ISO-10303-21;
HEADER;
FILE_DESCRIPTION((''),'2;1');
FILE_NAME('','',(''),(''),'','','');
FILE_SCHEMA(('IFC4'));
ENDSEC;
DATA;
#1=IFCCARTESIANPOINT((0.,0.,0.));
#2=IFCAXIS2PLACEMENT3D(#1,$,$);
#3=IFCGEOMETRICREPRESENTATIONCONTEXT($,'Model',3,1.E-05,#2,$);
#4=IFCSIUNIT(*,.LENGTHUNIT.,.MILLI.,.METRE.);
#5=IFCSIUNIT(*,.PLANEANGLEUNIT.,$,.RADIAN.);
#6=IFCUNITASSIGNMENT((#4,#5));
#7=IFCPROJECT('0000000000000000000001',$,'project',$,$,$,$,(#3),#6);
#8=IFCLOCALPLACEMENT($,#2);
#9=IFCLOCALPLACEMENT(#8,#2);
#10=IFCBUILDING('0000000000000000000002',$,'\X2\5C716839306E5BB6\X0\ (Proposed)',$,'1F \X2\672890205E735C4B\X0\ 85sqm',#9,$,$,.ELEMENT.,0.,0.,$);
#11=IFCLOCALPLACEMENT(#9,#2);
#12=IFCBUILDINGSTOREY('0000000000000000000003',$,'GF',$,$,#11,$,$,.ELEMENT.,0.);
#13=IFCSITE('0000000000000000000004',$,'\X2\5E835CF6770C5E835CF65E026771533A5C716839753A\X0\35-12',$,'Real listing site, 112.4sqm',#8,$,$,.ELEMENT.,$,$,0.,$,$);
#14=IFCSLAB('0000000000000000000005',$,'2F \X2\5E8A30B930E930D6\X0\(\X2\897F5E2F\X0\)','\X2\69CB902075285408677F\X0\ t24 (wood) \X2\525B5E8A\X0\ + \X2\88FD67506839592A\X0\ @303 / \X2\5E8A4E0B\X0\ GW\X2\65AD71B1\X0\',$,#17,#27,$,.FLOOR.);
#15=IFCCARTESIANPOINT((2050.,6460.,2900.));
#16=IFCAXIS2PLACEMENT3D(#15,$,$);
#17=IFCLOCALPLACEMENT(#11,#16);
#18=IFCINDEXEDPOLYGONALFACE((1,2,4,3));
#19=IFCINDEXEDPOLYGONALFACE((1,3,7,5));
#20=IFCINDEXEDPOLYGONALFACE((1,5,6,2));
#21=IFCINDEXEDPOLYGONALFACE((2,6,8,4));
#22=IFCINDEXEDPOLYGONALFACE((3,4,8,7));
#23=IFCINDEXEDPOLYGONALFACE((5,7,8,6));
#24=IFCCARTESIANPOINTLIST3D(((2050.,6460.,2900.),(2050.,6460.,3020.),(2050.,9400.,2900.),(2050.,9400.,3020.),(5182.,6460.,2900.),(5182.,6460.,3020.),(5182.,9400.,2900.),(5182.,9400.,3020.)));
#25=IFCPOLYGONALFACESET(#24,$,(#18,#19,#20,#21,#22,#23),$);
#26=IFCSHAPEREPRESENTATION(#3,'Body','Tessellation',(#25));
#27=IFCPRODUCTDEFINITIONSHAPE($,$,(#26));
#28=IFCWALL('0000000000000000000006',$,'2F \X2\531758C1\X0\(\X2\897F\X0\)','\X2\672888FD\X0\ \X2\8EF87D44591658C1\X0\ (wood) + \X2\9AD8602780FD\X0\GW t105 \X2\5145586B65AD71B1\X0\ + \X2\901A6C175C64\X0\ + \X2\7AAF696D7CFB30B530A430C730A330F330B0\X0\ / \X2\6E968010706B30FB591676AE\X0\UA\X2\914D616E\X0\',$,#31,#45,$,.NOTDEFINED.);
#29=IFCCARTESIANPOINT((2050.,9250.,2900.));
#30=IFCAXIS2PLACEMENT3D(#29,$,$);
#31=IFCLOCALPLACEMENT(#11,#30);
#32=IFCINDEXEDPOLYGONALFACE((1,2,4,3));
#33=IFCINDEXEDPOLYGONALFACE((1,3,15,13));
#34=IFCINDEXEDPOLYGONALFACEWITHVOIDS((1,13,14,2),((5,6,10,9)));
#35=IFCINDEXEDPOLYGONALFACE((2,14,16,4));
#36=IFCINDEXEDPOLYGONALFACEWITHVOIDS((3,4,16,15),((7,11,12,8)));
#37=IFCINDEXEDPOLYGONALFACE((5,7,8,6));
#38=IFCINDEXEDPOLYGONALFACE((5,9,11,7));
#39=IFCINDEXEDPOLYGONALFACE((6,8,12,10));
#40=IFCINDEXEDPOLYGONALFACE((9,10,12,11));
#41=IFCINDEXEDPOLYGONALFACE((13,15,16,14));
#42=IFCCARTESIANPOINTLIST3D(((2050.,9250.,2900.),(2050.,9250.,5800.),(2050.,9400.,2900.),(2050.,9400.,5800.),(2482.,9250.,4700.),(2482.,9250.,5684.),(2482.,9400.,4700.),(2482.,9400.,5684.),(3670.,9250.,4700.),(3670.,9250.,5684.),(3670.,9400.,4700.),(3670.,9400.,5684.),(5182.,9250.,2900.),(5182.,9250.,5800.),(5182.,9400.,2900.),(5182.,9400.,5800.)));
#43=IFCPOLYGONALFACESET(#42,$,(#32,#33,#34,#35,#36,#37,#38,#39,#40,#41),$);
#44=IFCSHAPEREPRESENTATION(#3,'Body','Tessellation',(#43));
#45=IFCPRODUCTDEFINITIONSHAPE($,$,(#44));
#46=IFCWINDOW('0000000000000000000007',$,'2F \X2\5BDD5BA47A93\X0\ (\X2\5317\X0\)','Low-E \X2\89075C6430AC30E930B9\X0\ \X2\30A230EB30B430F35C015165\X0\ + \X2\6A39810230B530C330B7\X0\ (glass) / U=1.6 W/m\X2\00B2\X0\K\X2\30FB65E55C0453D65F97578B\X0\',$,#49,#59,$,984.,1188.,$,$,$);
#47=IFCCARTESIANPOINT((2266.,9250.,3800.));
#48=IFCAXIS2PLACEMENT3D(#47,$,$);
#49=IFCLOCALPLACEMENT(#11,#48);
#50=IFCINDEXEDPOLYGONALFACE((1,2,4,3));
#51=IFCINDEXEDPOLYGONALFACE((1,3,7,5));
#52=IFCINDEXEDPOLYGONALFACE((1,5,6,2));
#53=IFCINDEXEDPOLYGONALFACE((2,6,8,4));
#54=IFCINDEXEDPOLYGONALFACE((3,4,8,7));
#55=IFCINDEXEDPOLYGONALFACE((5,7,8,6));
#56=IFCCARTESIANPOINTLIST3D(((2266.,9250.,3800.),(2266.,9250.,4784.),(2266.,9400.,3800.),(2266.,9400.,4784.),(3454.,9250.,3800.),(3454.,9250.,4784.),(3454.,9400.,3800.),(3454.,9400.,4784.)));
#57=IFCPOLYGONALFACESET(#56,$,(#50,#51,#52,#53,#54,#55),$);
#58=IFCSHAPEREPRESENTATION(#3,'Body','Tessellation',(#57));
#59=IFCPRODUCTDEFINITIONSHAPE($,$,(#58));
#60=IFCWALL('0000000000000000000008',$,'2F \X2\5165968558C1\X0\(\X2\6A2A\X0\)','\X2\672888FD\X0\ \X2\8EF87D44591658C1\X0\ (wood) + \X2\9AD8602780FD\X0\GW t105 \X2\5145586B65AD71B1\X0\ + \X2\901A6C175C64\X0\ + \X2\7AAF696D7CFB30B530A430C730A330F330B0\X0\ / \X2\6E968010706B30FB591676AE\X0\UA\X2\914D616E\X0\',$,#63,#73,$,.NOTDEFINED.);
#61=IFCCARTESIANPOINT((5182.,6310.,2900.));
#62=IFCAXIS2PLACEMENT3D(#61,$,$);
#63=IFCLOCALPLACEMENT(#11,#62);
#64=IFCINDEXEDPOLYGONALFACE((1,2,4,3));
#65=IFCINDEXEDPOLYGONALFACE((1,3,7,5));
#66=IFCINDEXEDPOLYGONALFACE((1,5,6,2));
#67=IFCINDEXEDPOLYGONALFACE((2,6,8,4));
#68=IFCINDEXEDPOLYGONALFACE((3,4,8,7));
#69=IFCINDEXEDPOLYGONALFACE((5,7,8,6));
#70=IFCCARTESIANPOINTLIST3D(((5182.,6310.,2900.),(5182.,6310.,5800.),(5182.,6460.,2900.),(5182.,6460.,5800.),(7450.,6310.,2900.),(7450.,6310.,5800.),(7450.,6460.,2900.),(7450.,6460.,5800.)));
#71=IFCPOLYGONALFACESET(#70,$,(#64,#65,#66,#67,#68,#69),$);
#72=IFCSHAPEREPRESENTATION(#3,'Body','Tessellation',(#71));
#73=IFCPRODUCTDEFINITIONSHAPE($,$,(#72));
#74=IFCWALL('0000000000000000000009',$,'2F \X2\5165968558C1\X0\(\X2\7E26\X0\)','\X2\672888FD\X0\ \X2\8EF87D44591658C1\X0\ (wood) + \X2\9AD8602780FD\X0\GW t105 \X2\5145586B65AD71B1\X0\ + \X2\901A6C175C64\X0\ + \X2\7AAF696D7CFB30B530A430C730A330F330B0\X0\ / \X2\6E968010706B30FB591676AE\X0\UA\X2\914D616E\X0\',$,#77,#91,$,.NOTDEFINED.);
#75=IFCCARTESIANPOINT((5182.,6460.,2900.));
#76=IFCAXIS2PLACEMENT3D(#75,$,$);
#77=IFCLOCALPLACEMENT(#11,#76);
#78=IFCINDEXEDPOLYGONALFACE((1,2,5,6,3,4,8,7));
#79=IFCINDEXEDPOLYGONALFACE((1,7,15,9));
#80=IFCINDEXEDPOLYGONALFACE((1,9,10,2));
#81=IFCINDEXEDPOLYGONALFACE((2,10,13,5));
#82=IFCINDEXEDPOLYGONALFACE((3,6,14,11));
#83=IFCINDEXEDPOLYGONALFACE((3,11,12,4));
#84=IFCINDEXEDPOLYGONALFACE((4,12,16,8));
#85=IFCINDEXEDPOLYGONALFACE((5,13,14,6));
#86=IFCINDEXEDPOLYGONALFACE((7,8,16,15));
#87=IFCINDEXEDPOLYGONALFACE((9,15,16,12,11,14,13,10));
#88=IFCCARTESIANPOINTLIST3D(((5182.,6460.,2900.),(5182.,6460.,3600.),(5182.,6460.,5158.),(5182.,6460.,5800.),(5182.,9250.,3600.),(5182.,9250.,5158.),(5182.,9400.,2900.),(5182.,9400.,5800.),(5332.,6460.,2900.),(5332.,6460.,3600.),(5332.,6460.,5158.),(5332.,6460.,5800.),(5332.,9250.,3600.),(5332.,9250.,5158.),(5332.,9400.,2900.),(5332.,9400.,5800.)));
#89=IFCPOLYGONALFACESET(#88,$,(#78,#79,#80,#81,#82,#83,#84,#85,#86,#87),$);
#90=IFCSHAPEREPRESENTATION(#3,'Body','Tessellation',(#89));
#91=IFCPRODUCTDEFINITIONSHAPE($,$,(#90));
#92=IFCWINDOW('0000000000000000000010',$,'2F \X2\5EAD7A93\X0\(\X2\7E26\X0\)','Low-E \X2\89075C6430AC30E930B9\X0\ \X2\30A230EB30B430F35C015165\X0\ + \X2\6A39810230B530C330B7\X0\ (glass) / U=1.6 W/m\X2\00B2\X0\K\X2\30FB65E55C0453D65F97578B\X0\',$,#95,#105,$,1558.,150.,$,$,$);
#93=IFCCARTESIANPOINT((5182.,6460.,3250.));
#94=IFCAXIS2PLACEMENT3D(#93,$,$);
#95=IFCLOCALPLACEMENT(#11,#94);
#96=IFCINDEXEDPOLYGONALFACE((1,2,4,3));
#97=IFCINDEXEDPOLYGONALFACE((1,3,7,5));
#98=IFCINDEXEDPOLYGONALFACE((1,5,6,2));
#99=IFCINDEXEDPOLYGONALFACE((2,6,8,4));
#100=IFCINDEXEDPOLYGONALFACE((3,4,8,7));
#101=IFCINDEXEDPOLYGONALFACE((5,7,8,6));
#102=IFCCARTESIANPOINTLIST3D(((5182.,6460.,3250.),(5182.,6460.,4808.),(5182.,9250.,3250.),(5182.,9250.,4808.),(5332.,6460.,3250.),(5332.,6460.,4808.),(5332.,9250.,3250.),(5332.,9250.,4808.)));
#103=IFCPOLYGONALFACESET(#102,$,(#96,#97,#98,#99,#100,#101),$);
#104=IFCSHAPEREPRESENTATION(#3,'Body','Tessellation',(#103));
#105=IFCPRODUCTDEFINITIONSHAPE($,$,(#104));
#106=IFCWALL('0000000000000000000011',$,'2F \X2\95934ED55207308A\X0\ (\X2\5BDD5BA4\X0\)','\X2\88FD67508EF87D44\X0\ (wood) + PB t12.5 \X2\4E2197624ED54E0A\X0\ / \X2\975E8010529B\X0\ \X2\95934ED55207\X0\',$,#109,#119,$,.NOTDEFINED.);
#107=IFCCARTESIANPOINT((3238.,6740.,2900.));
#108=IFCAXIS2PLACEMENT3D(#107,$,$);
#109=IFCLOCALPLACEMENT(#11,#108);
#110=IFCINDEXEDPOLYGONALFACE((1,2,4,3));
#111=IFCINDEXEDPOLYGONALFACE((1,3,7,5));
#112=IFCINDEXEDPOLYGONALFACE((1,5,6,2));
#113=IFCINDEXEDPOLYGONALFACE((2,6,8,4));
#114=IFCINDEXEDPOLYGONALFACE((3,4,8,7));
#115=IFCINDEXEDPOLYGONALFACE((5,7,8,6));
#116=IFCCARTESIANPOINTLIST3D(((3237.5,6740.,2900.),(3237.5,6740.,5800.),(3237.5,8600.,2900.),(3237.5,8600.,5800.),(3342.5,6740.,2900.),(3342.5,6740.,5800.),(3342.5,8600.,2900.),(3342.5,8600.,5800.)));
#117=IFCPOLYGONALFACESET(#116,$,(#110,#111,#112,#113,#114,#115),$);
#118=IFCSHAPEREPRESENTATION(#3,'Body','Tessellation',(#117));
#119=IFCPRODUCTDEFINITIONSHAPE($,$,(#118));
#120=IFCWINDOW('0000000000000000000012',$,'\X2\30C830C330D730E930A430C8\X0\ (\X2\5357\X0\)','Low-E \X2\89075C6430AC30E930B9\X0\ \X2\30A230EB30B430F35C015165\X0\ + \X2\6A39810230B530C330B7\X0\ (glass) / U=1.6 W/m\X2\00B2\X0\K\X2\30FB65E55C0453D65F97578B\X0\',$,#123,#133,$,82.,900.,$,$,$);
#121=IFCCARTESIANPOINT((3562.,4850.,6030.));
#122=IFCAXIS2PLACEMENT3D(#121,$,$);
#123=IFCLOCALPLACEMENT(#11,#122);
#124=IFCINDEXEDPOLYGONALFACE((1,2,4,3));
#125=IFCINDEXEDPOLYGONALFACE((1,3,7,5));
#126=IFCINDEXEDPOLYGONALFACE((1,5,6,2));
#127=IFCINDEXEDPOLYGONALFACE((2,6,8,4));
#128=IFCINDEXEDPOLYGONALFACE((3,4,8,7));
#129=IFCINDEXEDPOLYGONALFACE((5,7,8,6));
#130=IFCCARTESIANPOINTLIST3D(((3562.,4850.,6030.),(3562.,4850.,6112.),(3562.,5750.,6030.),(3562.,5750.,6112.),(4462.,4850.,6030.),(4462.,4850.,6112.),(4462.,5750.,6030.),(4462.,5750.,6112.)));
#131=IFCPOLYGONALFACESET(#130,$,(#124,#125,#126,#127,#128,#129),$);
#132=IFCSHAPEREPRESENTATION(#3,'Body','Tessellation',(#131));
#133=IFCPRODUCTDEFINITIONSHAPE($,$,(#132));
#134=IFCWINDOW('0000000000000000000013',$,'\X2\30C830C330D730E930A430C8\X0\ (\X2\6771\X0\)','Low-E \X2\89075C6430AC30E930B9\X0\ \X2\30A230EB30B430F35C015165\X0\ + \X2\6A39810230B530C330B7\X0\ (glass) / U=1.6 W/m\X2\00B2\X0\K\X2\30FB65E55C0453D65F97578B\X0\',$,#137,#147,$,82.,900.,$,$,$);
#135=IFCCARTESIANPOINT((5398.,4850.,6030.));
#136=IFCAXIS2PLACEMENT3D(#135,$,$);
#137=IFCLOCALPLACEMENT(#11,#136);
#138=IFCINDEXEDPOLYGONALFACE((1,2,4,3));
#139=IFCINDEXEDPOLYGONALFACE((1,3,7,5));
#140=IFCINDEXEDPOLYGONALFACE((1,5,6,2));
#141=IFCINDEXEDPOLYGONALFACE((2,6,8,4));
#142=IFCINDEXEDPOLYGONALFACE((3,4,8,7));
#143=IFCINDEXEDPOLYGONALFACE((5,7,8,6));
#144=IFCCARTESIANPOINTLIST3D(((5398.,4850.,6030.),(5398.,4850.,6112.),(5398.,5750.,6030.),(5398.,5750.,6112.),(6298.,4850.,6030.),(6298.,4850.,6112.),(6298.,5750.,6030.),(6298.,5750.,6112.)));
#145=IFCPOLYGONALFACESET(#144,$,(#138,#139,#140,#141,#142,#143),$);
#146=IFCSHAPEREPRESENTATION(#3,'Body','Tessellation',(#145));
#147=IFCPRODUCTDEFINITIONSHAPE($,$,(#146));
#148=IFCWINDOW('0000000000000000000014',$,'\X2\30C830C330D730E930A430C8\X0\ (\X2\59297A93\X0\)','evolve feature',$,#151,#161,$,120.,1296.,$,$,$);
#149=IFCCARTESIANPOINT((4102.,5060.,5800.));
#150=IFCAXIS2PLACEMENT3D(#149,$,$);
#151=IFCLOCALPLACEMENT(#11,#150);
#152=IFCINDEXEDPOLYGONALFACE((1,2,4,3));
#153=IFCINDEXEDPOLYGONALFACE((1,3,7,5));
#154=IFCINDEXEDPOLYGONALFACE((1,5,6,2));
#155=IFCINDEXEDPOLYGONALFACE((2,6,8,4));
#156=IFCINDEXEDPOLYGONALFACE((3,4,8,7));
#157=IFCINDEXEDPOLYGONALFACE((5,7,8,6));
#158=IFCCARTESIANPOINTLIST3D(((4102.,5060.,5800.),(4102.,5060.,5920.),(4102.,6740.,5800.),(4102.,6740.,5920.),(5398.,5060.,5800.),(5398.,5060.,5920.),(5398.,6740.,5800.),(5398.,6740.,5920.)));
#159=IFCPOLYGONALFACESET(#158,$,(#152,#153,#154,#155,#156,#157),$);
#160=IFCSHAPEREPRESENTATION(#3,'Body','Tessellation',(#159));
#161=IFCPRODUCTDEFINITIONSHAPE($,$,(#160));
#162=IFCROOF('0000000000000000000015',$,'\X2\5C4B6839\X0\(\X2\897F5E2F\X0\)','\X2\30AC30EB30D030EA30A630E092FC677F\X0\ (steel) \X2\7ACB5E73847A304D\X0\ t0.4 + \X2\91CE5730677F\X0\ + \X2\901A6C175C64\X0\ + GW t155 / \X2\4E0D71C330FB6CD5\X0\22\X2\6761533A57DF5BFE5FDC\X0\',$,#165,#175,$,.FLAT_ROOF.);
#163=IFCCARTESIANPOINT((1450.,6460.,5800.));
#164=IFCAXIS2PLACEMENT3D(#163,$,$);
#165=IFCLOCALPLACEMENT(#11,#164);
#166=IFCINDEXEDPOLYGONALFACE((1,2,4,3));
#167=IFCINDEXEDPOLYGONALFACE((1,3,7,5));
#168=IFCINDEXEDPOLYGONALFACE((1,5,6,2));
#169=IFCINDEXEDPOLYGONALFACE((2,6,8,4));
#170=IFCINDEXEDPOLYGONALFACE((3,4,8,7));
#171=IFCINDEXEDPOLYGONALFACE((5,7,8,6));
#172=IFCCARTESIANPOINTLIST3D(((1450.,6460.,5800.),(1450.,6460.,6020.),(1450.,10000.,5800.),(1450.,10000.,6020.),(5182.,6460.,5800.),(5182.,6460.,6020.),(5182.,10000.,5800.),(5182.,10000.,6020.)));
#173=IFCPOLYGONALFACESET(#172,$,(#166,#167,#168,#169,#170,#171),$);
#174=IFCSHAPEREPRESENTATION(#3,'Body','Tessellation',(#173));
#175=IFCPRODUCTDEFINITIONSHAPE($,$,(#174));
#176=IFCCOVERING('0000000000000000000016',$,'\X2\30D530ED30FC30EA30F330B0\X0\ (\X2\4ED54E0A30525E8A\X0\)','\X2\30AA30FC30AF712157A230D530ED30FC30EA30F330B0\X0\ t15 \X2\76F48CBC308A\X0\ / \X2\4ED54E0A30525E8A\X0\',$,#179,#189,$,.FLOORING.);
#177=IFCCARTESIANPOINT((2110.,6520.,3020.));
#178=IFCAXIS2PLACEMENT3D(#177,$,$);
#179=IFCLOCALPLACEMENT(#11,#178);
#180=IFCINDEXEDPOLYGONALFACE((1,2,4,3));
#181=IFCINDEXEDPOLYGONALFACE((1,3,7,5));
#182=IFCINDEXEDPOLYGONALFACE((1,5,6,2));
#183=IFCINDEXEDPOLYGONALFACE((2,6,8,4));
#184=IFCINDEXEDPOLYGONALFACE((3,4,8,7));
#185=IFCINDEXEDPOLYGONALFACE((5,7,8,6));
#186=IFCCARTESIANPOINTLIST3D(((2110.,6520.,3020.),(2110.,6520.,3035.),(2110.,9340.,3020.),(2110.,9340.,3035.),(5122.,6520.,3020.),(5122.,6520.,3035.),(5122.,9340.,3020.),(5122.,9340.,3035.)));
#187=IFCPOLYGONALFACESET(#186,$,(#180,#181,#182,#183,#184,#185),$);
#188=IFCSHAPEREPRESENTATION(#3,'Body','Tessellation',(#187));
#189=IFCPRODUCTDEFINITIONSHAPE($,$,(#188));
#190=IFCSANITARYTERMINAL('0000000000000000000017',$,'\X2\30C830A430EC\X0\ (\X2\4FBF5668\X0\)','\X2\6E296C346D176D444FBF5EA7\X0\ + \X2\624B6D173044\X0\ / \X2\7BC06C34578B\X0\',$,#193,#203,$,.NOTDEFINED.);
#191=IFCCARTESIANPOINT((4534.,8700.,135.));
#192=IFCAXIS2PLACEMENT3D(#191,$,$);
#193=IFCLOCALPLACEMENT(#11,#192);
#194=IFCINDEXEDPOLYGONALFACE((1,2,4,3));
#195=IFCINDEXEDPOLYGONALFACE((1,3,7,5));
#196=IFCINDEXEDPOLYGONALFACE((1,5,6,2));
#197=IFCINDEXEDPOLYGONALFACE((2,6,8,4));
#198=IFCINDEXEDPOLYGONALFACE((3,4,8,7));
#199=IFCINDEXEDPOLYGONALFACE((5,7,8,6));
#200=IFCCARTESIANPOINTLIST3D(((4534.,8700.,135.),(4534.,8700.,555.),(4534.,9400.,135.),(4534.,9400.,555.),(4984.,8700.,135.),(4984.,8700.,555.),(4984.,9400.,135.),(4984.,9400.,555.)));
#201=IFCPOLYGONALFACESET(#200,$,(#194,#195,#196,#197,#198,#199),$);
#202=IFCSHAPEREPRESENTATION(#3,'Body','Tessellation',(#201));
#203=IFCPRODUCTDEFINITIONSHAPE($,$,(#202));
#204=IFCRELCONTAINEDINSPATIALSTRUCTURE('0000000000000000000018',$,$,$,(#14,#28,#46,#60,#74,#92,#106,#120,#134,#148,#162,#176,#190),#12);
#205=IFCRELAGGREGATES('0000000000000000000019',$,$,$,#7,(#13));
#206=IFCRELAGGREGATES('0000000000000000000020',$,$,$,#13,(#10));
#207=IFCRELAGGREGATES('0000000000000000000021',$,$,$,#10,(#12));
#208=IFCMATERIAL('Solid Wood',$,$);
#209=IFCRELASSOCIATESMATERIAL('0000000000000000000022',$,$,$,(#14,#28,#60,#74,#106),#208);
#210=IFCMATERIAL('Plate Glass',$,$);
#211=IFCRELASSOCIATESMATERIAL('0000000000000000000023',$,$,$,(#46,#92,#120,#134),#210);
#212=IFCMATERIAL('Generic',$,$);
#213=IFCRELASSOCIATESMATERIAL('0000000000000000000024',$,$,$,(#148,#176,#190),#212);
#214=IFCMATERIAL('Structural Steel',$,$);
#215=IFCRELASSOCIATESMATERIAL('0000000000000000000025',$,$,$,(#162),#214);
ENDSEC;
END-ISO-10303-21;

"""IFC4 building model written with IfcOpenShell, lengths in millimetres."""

from ifc_helpers import new_model, si_unit, frame, frame_2d, origin, place, context, project, spatial, rectangle, extrude, material, element, fill, save


model = new_model("IFC4")

# Units and contexts
model_context = context("Model", 3, precision=1e-05, world=origin())
ifc_project = project(units=[si_unit("LENGTHUNIT", "METRE", prefix="MILLI"), si_unit("PLANEANGLEUNIT", "RADIAN")], contexts=[model_context])

# Site, building, storey
site_placement = place(None, origin())
site = spatial("IfcSite", under=ifc_project, at=site_placement, Name="広島県広島市東区山根町35-12", ObjectType="Real listing site, 112.4sqm", CompositionType="ELEMENT", RefElevation=0.0)
building_placement = place(site_placement, origin())
building = spatial("IfcBuilding", under=site, at=building_placement, Name="山根の家 (Proposed)", ObjectType="1F 木造平屋 85sqm", CompositionType="ELEMENT", ElevationOfRefHeight=0.0, ElevationOfTerrain=0.0)
storey_placement = place(building_placement, origin())
storey = spatial("IfcBuildingStorey", under=building, at=storey_placement, Name="GF", CompositionType="ELEMENT", Elevation=0.0)

# Slab
ifc_material_1 = material(Name="Solid Wood")
slab_placement = place(storey_placement, frame((2050.0, 6460.0, 2900.0)))
element("IfcSlab", 1, at=slab_placement, inside=storey, material=ifc_material_1, Name="2F 床スラブ(西帯)", Description="構造用合板 t24 (wood) 剛床 + 製材根太 @303 / 床下 GW断熱", PredefinedType="FLOOR", context=model_context, shape_type="SweptSolid", body=[
    extrude(rectangle(XDim=3132.0, YDim=2940.0, at=frame_2d((1566.0, 1470.0))), frame((2050.0, 6460.0, 2900.0)), (0.0, 0.0, 1.0), 120.0),
])

# Wall, opening, window
wall_1_placement = place(storey_placement, frame((2050.0, 9250.0, 2900.0)))
wall_1 = element("IfcWall", 2, at=wall_1_placement, inside=storey, material=ifc_material_1, Name="2F 北壁(西)", Description="木製 軸組外壁 (wood) + 高性能GW t105 充填断熱 + 通気層 + 窯業系サイディング / 準耐火・外皮UA配慮", PredefinedType="NOTDEFINED", context=model_context, shape_type="SweptSolid", body=[
    extrude(rectangle(XDim=3132.0, YDim=150.0, at=frame_2d((1566.0, 75.0))), frame((2050.0, 9250.0, 2900.0)), (0.0, 0.0, 1.0), 2900.0),
])
opening_1_placement = place(storey_placement, frame((2266.0, 9250.0, 3800.0)))
opening_1 = element("IfcOpeningElement", 3, at=opening_1_placement, cuts=wall_1, PredefinedType="NOTDEFINED", context=model_context, shape_type="SweptSolid", body=[
    extrude(rectangle(XDim=1188.0, YDim=150.0, at=frame_2d((594.0, 75.0))), frame((2266.0, 9250.0, 3800.0)), (0.0, 0.0, 1.0), 984.0),
])
ifc_material_2 = material(Name="Plate Glass")
window_1_placement = place(storey_placement, frame((2266.0, 9250.0, 3800.0)))
window_1 = element("IfcWindow", 4, at=window_1_placement, inside=storey, material=ifc_material_2, Name="2F 寝室窓 (北)", Description="Low-E 複層ガラス アルゴン封入 + 樹脂サッシ (glass) / U=1.6 W/m²K・日射取得型", OverallHeight=984.0, OverallWidth=1188.0, context=model_context, shape_type="SweptSolid", body=[
    extrude(rectangle(XDim=1188.0, YDim=150.0, at=frame_2d((594.0, 75.0))), frame((2266.0, 9250.0, 3800.0)), (0.0, 0.0, 1.0), 984.0),
])
fill(opening_1, window_1)

# Wall
wall_2_placement = place(storey_placement, frame((5182.0, 6310.0, 2900.0)))
element("IfcWall", 5, at=wall_2_placement, inside=storey, material=ifc_material_1, Name="2F 入隅壁(横)", Description="木製 軸組外壁 (wood) + 高性能GW t105 充填断熱 + 通気層 + 窯業系サイディング / 準耐火・外皮UA配慮", PredefinedType="NOTDEFINED", context=model_context, shape_type="SweptSolid", body=[
    extrude(rectangle(XDim=2268.0, YDim=150.0, at=frame_2d((1134.0, 75.0))), frame((5182.0, 6310.0, 2900.0)), (0.0, 0.0, 1.0), 2900.0),
])

# Wall, opening, window
wall_3_placement = place(storey_placement, frame((5182.0, 6460.0, 2900.0)))
wall_3 = element("IfcWall", 6, at=wall_3_placement, inside=storey, material=ifc_material_1, Name="2F 入隅壁(縦)", Description="木製 軸組外壁 (wood) + 高性能GW t105 充填断熱 + 通気層 + 窯業系サイディング / 準耐火・外皮UA配慮", PredefinedType="NOTDEFINED", context=model_context, shape_type="SweptSolid", body=[
    extrude(rectangle(XDim=150.0, YDim=2940.0, at=frame_2d((75.0, 1470.0))), frame((5182.0, 6460.0, 2900.0)), (0.0, 0.0, 1.0), 2900.0),
])
opening_2_placement = place(storey_placement, frame((5182.0, 6460.0, 3250.0)))
opening_2 = element("IfcOpeningElement", 7, at=opening_2_placement, cuts=wall_3, PredefinedType="NOTDEFINED", context=model_context, shape_type="SweptSolid", body=[
    extrude(rectangle(XDim=150.0, YDim=2790.0, at=frame_2d((75.0, 1395.0))), frame((5182.0, 6460.0, 3250.0)), (0.0, 0.0, 1.0), 1558.0),
])
window_2_placement = place(storey_placement, frame((5182.0, 6460.0, 3250.0)))
window_2 = element("IfcWindow", 8, at=window_2_placement, inside=storey, material=ifc_material_2, Name="2F 庭窓(縦)", Description="Low-E 複層ガラス アルゴン封入 + 樹脂サッシ (glass) / U=1.6 W/m²K・日射取得型", OverallHeight=1558.0, OverallWidth=150.0, context=model_context, shape_type="SweptSolid", body=[
    extrude(rectangle(XDim=150.0, YDim=2790.0, at=frame_2d((75.0, 1395.0))), frame((5182.0, 6460.0, 3250.0)), (0.0, 0.0, 1.0), 1558.0),
])
fill(opening_2, window_2)

# Wall
wall_4_placement = place(storey_placement, frame((3238.0, 6740.0, 2900.0)))
element("IfcWall", 9, at=wall_4_placement, inside=storey, material=ifc_material_1, Name="2F 間仕切り (寝室)", Description="製材軸組 (wood) + PB t12.5 両面仕上 / 非耐力 間仕切", PredefinedType="NOTDEFINED", context=model_context, shape_type="SweptSolid", body=[
    extrude(rectangle(XDim=105.0, YDim=1860.0, at=frame_2d((52.0, 930.0))), frame((3238.0, 6740.0, 2900.0)), (0.0, 0.0, 1.0), 2900.0),
])

# Windows
window_3_placement = place(storey_placement, frame((3562.0, 4850.0, 6030.0)))
element("IfcWindow", 10, at=window_3_placement, inside=storey, material=ifc_material_2, Name="トップライト (南)", Description="Low-E 複層ガラス アルゴン封入 + 樹脂サッシ (glass) / U=1.6 W/m²K・日射取得型", OverallHeight=82.0, OverallWidth=900.0, context=model_context, shape_type="SweptSolid", body=[
    extrude(rectangle(XDim=900.0, YDim=900.0, at=frame_2d((450.0, 450.0))), frame((3562.0, 4850.0, 6030.0)), (0.0, 0.0, 1.0), 82.0),
])
window_4_placement = place(storey_placement, frame((5398.0, 4850.0, 6030.0)))
element("IfcWindow", 11, at=window_4_placement, inside=storey, material=ifc_material_2, Name="トップライト (東)", Description="Low-E 複層ガラス アルゴン封入 + 樹脂サッシ (glass) / U=1.6 W/m²K・日射取得型", OverallHeight=82.0, OverallWidth=900.0, context=model_context, shape_type="SweptSolid", body=[
    extrude(rectangle(XDim=900.0, YDim=900.0, at=frame_2d((450.0, 450.0))), frame((5398.0, 4850.0, 6030.0)), (0.0, 0.0, 1.0), 82.0),
])
ifc_material_3 = material(Name="Generic")
window_5_placement = place(storey_placement, frame((4102.0, 5060.0, 5800.0)))
element("IfcWindow", 12, at=window_5_placement, inside=storey, material=ifc_material_3, Name="トップライト (天窓)", Description="evolve feature", OverallHeight=120.0, OverallWidth=1296.0, context=model_context, shape_type="SweptSolid", body=[
    extrude(rectangle(XDim=1296.0, YDim=1680.0, at=frame_2d((648.0, 840.0))), frame((4102.0, 5060.0, 5800.0)), (0.0, 0.0, 1.0), 120.0),
])

# Roof
ifc_material_4 = material(Name="Structural Steel")
for number, where, name in (
    (13, (1450.0, 6460.0, 5800.0), "屋根(西帯)"),
):
    element("IfcRoof", number, at=place(storey_placement, frame(where)), inside=storey, material=ifc_material_4, Name=name, Description="ガルバリウム鋼板 (steel) 立平葺き t0.4 + 野地板 + 通気層 + GW t155 / 不燃・法22条区域対応", PredefinedType="FLAT_ROOF", context=model_context, shape_type="SweptSolid", body=[
        extrude(rectangle(XDim=3732.0, YDim=3540.0, at=frame_2d((1866.0, 1770.0))), frame((1450.0, 6460.0, 5800.0)), (0.0, 0.0, 1.0), 220.0),
    ])

# Covering
covering_placement = place(storey_placement, frame((2110.0, 6520.0, 3020.0)))
element("IfcCovering", 14, at=covering_placement, inside=storey, material=ifc_material_3, Name="フローリング (仕上げ床)", Description="オーク無垢フローリング t15 直貼り / 仕上げ床", PredefinedType="FLOORING", context=model_context, shape_type="SweptSolid", body=[
    extrude(rectangle(XDim=3012.0, YDim=2820.0, at=frame_2d((1506.0, 1410.0))), frame((2110.0, 6520.0, 3020.0)), (0.0, 0.0, 1.0), 15.0),
])

# Sanitary terminal
sanitary_terminal_placement = place(storey_placement, frame((4534.0, 8700.0, 135.0)))
element("IfcSanitaryTerminal", 15, at=sanitary_terminal_placement, inside=storey, material=ifc_material_3, Name="トイレ (便器)", Description="温水洗浄便座 + 手洗い / 節水型", PredefinedType="NOTDEFINED", context=model_context, shape_type="SweptSolid", body=[
    extrude(rectangle(XDim=450.0, YDim=700.0, at=frame_2d((225.0, 350.0))), frame((4534.0, 8700.0, 135.0)), (0.0, 0.0, 1.0), 420.0),
])

save(model, "model.ifc")
